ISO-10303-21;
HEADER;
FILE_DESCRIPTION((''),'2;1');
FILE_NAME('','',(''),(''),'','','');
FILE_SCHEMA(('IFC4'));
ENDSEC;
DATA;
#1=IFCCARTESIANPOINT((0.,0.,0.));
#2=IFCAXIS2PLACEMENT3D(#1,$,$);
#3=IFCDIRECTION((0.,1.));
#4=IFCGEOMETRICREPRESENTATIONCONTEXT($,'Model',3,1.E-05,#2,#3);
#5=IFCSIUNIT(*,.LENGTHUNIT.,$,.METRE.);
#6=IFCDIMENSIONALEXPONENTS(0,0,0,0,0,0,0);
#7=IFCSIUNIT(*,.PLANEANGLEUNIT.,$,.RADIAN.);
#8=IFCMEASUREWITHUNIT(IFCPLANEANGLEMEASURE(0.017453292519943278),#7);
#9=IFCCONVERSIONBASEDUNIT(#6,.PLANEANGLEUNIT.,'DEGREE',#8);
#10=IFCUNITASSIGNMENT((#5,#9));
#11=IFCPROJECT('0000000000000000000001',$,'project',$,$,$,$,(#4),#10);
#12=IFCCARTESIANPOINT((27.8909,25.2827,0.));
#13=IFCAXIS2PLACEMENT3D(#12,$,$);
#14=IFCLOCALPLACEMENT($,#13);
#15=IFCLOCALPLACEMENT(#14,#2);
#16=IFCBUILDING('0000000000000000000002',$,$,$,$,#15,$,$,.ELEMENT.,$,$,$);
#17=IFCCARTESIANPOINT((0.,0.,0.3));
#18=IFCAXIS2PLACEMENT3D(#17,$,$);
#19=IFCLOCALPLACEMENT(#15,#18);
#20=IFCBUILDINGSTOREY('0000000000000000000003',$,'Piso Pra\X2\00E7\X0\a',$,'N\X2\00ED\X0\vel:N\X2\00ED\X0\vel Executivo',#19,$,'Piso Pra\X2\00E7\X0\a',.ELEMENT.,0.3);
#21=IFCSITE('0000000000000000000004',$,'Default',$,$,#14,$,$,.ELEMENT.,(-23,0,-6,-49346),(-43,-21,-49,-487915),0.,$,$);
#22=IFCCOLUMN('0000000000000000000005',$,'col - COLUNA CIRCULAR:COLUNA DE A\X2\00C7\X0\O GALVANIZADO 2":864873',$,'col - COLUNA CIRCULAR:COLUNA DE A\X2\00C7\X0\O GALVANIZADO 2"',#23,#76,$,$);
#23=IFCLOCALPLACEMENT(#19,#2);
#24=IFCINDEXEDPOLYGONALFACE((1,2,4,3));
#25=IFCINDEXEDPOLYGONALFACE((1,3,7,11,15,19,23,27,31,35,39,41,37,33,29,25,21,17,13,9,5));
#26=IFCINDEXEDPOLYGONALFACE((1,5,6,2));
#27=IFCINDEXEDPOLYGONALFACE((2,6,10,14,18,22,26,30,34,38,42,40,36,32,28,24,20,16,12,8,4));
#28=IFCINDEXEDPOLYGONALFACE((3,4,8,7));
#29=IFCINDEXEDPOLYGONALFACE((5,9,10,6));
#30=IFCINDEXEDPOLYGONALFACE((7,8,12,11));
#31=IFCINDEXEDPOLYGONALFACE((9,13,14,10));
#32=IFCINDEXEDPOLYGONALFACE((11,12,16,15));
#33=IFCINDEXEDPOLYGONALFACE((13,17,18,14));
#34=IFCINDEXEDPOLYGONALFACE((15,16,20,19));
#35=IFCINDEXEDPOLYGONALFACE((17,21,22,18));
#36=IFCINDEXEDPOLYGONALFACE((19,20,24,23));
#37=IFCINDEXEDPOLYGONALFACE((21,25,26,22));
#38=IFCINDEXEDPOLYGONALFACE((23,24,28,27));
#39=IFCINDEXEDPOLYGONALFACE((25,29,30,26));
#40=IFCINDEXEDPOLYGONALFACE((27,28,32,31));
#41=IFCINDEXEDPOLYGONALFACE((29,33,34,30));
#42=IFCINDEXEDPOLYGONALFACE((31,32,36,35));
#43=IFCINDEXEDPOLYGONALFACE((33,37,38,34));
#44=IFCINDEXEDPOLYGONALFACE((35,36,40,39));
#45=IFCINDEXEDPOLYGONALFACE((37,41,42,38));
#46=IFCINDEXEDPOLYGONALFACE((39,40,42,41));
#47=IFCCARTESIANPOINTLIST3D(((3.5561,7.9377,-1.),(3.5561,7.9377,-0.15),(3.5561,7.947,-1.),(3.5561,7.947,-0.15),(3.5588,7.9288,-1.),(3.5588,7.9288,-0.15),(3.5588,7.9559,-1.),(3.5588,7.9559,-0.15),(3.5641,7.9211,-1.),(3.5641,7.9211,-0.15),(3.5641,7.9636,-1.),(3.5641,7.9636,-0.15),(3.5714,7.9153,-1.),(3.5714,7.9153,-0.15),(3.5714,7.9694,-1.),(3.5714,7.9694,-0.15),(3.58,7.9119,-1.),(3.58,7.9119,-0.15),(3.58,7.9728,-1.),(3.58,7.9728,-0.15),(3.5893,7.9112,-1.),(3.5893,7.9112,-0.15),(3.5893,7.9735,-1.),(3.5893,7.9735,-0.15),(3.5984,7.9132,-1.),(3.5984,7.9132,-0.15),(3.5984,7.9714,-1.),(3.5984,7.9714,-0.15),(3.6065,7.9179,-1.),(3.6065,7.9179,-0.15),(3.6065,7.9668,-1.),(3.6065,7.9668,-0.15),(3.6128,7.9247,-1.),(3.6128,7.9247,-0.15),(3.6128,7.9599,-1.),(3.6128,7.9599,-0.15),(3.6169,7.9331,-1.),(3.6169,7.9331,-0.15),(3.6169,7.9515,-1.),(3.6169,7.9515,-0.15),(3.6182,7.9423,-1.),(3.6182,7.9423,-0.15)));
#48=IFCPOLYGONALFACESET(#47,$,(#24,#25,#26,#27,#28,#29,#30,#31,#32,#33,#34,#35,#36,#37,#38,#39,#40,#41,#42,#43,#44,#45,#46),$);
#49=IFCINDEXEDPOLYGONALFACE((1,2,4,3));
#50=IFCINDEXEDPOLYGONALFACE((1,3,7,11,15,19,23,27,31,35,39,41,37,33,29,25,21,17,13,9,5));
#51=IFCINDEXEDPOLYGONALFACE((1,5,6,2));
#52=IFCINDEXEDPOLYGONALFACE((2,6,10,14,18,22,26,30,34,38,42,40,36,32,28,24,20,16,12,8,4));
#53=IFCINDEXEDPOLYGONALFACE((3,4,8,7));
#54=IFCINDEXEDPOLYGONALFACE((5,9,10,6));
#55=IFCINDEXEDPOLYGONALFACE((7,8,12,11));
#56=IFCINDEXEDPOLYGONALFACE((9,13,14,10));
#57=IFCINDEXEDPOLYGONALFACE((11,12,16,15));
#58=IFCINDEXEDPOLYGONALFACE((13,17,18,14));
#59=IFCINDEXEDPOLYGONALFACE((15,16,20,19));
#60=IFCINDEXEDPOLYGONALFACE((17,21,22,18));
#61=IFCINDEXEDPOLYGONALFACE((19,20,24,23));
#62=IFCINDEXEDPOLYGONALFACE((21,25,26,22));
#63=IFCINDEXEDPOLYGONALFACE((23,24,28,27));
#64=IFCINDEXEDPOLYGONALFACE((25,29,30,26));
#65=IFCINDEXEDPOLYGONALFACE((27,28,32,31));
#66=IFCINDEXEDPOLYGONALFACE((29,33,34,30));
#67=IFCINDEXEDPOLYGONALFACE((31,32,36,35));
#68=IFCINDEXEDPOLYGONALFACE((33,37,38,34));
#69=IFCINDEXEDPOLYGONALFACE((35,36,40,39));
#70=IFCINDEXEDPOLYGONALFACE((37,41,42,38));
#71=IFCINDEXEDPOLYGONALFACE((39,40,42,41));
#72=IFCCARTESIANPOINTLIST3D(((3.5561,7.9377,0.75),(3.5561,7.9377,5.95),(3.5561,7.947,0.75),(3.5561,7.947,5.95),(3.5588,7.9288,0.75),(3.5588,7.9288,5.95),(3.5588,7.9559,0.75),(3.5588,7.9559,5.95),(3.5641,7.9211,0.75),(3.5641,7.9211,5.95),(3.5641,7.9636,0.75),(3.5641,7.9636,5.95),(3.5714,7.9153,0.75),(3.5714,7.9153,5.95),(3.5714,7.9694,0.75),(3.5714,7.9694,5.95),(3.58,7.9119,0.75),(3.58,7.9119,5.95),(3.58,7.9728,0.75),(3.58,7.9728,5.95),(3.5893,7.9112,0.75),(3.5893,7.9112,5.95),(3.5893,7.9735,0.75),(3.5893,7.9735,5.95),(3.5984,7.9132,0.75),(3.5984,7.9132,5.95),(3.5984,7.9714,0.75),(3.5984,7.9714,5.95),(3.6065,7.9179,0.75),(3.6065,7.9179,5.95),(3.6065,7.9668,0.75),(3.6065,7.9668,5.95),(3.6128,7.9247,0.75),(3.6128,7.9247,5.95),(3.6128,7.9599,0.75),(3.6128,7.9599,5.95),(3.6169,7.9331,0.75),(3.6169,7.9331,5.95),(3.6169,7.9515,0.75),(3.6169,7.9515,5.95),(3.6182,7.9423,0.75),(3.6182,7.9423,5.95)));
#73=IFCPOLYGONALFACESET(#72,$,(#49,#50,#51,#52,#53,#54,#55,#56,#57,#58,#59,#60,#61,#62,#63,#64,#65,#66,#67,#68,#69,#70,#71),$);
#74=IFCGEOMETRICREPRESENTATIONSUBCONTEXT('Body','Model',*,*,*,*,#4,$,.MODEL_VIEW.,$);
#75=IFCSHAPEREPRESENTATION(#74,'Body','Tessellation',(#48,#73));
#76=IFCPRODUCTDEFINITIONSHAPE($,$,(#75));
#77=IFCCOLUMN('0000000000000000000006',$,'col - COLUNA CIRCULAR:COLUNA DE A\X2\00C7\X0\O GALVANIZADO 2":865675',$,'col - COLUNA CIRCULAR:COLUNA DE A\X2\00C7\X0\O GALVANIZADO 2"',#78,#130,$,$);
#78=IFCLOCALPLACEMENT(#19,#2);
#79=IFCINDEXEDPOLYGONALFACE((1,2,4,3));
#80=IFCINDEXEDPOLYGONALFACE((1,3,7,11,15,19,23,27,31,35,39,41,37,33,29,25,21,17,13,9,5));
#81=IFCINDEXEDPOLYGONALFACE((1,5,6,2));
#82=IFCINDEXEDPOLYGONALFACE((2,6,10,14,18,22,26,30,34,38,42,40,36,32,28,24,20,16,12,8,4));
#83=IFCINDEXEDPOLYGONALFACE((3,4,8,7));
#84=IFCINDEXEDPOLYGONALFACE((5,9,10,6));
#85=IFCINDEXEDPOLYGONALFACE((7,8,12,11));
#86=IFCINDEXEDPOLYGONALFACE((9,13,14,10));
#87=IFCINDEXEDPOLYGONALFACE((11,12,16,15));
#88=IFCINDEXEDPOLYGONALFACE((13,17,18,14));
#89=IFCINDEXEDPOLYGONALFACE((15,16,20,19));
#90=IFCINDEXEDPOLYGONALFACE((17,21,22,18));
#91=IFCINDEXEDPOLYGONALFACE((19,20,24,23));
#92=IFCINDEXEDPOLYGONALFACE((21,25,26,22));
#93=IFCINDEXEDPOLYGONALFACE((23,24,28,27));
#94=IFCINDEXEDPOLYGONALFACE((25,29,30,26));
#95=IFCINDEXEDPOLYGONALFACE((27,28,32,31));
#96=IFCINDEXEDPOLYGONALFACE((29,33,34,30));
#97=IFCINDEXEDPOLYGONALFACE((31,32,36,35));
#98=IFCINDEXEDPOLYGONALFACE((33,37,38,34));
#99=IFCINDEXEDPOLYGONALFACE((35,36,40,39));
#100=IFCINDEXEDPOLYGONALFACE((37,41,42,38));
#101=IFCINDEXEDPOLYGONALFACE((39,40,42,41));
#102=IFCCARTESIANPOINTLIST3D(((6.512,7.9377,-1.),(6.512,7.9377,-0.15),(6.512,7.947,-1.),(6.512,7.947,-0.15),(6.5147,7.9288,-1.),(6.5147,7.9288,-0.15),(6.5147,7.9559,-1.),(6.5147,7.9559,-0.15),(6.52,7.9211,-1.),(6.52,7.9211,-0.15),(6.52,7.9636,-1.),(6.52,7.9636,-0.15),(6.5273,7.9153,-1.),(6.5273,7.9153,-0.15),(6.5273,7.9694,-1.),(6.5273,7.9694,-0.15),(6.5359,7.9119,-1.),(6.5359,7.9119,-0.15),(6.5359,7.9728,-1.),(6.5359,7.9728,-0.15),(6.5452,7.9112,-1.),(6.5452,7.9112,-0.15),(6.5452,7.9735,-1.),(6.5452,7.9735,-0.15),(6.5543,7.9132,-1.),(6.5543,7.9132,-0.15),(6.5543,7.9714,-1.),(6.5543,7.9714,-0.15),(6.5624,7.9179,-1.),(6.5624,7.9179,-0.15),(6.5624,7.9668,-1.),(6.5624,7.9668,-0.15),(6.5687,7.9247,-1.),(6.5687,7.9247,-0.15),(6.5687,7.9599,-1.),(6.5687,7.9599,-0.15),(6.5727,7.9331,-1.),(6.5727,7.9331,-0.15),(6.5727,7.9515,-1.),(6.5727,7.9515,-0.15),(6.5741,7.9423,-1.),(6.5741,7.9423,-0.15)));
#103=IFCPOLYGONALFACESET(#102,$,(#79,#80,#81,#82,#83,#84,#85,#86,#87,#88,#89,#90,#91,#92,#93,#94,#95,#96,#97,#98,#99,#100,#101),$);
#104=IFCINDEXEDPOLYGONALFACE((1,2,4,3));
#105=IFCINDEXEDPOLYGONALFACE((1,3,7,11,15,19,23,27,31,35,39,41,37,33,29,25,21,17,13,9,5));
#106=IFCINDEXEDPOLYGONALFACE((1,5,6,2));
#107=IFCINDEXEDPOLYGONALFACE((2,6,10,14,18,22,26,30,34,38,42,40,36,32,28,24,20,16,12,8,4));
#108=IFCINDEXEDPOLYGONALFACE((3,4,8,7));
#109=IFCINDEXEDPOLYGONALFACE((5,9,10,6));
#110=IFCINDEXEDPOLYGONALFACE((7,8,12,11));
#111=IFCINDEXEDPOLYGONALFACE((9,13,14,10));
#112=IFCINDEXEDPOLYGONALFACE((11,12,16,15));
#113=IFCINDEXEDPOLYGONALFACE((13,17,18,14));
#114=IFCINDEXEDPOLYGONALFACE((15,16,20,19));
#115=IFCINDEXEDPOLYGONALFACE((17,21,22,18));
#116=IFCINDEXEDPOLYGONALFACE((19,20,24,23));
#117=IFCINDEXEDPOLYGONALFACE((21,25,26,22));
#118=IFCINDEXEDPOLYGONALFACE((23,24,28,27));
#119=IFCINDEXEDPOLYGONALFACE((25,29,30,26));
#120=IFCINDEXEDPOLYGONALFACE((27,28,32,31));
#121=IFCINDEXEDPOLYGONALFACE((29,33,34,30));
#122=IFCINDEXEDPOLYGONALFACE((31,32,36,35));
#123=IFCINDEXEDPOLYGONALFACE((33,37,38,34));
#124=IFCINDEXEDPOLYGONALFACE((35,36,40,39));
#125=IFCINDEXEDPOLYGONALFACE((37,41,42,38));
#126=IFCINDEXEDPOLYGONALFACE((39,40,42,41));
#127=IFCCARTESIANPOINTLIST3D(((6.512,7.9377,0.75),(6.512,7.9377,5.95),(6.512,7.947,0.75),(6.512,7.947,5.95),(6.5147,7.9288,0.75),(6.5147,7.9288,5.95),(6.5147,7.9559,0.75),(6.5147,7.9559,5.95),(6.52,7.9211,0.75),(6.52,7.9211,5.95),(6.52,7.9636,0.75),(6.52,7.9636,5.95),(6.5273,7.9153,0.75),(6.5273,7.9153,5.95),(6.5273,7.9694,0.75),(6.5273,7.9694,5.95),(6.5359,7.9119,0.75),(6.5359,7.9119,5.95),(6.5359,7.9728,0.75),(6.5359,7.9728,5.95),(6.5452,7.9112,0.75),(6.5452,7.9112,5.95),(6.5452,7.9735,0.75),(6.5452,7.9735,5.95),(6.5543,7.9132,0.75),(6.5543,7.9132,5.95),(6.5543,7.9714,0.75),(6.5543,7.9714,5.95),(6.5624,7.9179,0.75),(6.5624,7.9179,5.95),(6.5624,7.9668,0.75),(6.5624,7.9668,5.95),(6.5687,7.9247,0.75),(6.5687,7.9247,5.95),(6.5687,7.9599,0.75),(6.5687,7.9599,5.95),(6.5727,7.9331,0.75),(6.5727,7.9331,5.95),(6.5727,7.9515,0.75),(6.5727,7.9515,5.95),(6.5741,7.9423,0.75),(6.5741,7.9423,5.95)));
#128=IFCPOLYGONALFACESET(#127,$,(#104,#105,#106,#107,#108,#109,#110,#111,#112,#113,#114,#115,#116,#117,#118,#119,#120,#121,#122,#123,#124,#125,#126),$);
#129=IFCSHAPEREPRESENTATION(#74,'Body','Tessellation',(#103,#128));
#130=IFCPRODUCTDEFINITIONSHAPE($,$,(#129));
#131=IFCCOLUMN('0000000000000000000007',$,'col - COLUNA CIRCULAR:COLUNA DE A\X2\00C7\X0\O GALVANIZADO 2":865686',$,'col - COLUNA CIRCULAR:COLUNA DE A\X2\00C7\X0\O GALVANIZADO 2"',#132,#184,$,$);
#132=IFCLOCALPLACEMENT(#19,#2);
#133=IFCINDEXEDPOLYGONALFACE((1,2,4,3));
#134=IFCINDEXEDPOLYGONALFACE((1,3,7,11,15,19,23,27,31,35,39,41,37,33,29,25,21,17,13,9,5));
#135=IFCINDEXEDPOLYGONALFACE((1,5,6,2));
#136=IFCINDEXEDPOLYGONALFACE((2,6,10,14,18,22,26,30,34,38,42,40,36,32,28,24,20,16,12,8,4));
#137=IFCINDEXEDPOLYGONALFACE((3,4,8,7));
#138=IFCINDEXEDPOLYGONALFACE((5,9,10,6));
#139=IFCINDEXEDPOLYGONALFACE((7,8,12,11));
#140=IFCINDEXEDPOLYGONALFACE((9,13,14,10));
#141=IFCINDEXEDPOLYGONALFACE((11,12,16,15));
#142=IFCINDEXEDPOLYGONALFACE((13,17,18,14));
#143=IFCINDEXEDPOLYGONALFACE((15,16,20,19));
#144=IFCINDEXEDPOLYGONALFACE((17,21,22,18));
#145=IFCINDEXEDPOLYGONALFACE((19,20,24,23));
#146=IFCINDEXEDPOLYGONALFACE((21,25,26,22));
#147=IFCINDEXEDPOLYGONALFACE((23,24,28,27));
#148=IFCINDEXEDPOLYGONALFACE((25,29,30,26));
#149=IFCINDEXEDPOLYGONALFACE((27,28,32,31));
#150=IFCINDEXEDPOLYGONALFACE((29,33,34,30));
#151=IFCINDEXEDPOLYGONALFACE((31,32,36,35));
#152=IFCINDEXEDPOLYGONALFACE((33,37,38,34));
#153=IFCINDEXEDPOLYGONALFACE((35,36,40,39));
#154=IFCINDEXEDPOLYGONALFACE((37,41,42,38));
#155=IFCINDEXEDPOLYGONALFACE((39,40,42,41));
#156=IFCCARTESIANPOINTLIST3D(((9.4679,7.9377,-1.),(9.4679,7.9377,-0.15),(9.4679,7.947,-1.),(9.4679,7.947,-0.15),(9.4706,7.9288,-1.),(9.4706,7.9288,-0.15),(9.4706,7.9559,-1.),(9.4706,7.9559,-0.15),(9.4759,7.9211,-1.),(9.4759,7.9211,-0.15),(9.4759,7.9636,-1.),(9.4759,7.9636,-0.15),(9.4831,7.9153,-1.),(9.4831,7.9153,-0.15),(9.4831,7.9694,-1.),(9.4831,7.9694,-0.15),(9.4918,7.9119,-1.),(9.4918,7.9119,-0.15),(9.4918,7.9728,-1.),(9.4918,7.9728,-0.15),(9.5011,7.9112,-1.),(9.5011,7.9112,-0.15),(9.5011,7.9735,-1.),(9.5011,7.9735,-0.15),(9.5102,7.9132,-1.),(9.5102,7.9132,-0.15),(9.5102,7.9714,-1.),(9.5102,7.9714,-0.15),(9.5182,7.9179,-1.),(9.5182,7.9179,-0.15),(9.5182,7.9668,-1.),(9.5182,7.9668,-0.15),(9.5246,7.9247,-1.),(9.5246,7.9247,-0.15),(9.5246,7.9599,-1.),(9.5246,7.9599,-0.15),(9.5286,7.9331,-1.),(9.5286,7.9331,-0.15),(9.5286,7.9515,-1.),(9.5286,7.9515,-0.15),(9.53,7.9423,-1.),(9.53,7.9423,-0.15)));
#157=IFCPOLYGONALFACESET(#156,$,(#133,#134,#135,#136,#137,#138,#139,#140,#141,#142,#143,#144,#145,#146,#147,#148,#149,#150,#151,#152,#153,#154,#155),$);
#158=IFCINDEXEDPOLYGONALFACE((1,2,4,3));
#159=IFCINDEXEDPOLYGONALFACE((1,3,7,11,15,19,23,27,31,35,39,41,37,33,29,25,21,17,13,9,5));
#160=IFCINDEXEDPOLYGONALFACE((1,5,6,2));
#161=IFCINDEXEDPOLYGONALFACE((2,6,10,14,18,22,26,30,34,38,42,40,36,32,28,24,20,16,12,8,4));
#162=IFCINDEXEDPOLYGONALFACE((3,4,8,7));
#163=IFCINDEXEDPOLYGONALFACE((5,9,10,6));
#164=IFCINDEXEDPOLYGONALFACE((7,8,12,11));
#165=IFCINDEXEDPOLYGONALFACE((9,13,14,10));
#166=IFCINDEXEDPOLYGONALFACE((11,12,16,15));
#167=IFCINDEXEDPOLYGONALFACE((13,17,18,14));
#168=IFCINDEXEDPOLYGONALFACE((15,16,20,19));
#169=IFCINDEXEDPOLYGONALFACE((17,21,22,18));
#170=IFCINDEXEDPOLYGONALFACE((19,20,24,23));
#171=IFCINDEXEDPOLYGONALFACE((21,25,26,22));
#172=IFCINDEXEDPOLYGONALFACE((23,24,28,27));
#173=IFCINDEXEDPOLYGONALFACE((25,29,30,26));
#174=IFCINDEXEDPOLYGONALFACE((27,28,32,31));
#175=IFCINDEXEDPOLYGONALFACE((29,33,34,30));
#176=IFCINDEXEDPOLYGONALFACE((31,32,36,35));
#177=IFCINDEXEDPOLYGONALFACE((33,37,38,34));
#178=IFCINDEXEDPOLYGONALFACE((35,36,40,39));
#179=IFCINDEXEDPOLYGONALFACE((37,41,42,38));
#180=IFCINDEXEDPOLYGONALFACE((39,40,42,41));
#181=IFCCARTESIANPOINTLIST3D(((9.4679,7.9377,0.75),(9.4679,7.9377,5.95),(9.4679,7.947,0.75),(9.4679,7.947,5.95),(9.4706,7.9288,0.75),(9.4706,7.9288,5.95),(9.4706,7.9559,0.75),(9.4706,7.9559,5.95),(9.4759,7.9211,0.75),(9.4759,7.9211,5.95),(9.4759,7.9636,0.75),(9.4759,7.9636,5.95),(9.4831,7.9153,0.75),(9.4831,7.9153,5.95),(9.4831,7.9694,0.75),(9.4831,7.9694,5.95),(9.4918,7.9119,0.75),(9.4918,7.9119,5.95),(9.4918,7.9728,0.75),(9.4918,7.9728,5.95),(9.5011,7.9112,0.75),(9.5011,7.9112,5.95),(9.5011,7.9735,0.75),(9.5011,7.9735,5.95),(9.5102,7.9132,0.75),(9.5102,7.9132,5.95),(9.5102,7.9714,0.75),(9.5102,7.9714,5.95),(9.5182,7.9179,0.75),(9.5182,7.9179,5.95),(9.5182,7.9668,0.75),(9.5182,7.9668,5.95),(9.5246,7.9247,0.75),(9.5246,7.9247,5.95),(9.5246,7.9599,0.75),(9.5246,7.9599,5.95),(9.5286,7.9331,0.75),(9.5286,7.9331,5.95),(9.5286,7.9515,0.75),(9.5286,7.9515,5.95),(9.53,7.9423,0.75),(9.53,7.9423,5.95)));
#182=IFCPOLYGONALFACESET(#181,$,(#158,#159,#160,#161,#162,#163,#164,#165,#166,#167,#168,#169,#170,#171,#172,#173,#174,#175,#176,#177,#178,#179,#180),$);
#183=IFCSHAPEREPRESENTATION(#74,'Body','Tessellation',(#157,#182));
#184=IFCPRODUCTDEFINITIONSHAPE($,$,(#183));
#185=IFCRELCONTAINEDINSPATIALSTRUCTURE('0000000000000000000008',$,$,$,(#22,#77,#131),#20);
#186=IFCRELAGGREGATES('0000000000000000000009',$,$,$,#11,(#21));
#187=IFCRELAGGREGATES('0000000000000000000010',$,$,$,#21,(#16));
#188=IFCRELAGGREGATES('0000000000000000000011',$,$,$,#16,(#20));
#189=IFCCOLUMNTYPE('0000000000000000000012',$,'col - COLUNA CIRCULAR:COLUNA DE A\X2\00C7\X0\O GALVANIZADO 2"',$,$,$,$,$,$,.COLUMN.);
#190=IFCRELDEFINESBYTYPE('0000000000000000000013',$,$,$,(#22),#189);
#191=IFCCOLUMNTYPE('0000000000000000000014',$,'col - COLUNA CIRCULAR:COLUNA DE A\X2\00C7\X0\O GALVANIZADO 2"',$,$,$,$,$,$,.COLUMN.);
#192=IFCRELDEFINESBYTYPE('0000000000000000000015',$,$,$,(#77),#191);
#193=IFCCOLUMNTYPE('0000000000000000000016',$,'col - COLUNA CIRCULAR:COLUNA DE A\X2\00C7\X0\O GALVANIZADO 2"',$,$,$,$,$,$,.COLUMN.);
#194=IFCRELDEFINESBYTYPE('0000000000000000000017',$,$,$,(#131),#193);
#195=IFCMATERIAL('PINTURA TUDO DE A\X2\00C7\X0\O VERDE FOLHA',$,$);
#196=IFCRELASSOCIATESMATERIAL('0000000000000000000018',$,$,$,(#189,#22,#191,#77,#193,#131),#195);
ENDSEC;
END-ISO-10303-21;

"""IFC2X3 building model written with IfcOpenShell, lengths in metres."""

from ifc_helpers import new_model, entity, si_unit, converted_unit, direction, frame, origin, origin_2d_with_axis, place, context, subcontext, project, spatial, circle, extrude, source, transform, mapped, material, type_object, type_shapes, element, save


model = new_model("IFC2X3")

# Units and contexts
model_context = context("Model", 3, precision=1e-05, world=origin(), true_north=direction((0.0, 1.0)))
body_context = subcontext(model_context, "Body", "Model", "MODEL_VIEW")
ifc_project = project(units=[si_unit("LENGTHUNIT", "METRE"), converted_unit("PLANEANGLEUNIT", "DEGREE", entity("IfcPlaneAngleMeasure", 0.017453292519943278), si_unit("PLANEANGLEUNIT", "RADIAN"), dimensions=[0, 0, 0, 0, 0, 0, 0])], contexts=[model_context])

# Site, building, storey
site_placement = place(None, frame((27.8909, 25.2827, 0.0)))
site = spatial("IfcSite", under=ifc_project, at=site_placement, Name="Default", CompositionType="ELEMENT", RefLatitude=(-23, 0, -6, -49346), RefLongitude=(-43, -21, -49, -487915), RefElevation=0.0)
building_placement = place(site_placement, origin())
building = spatial("IfcBuilding", under=site, at=building_placement, CompositionType="ELEMENT")
storey_placement = place(building_placement, frame((0.0, 0.0, 0.3)))
storey = spatial("IfcBuildingStorey", under=building, at=storey_placement, Name="Piso Praça", ObjectType="Nível:Nível Executivo", LongName="Piso Praça", CompositionType="ELEMENT", Elevation=0.3)

# Columns
ifc_material_1 = material(Name="PINTURA TUDO DE AÇO VERDE FOLHA")
column_type_1 = type_object("IfcColumnType", Name="col - COLUNA CIRCULAR:COLUNA DE AÇO GALVANIZADO 2\"", PredefinedType="COLUMN", material=ifc_material_1)
shared_shape_1 = source(origin(), body_context, "Body", "SweptSolid", [
    extrude(circle(Radius=0.0312, at=origin_2d_with_axis()), frame((3.587, 7.9423, -0.7)), (0.0, 0.0, 1.0), 0.85),
    extrude(circle(Radius=0.0312, at=origin_2d_with_axis()), frame((3.587, 7.9423, 1.05)), (0.0, 0.0, 1.0), 5.2),
])
type_shapes(column_type_1, [shared_shape_1])
column_1_placement = place(storey_placement, frame((0.0, 0.0, -0.3)))
element("IfcColumn", 1, at=column_1_placement, inside=storey, type_object=column_type_1, material=ifc_material_1, Name="col - COLUNA CIRCULAR:COLUNA DE AÇO GALVANIZADO 2\":864873", ObjectType="col - COLUNA CIRCULAR:COLUNA DE AÇO GALVANIZADO 2\"", context=body_context, shape_type="MappedRepresentation", body=[
    mapped(shared_shape_1, transform((0.0, 0.0, 0.0), scale=1.0)),
])
column_type_2 = type_object("IfcColumnType", Name="col - COLUNA CIRCULAR:COLUNA DE AÇO GALVANIZADO 2\"", PredefinedType="COLUMN", material=ifc_material_1)
shared_shape_2 = source(origin(), body_context, "Body", "SweptSolid", [
    extrude(circle(Radius=0.0312, at=origin_2d_with_axis()), frame((6.5429, 7.9423, -0.7)), (0.0, 0.0, 1.0), 0.85),
    extrude(circle(Radius=0.0312, at=origin_2d_with_axis()), frame((6.5429, 7.9423, 1.05)), (0.0, 0.0, 1.0), 5.2),
])
type_shapes(column_type_2, [shared_shape_2])
column_2_placement = place(storey_placement, frame((0.0, 0.0, -0.3)))
element("IfcColumn", 2, at=column_2_placement, inside=storey, type_object=column_type_2, material=ifc_material_1, Name="col - COLUNA CIRCULAR:COLUNA DE AÇO GALVANIZADO 2\":865675", ObjectType="col - COLUNA CIRCULAR:COLUNA DE AÇO GALVANIZADO 2\"", context=body_context, shape_type="MappedRepresentation", body=[
    mapped(shared_shape_2, transform((0.0, 0.0, 0.0), scale=1.0)),
])
column_type_3 = type_object("IfcColumnType", Name="col - COLUNA CIRCULAR:COLUNA DE AÇO GALVANIZADO 2\"", PredefinedType="COLUMN", material=ifc_material_1)
shared_shape_3 = source(origin(), body_context, "Body", "SweptSolid", [
    extrude(circle(Radius=0.0312, at=origin_2d_with_axis()), frame((9.4988, 7.9423, -0.7)), (0.0, 0.0, 1.0), 0.85),
    extrude(circle(Radius=0.0312, at=origin_2d_with_axis()), frame((9.4988, 7.9423, 1.05)), (0.0, 0.0, 1.0), 5.2),
])
type_shapes(column_type_3, [shared_shape_3])
column_3_placement = place(storey_placement, frame((0.0, 0.0, -0.3)))
element("IfcColumn", 3, at=column_3_placement, inside=storey, type_object=column_type_3, material=ifc_material_1, Name="col - COLUNA CIRCULAR:COLUNA DE AÇO GALVANIZADO 2\":865686", ObjectType="col - COLUNA CIRCULAR:COLUNA DE AÇO GALVANIZADO 2\"", context=body_context, shape_type="MappedRepresentation", body=[
    mapped(shared_shape_3, transform((0.0, 0.0, 0.0), scale=1.0)),
])

save(model, "model.ifc")
